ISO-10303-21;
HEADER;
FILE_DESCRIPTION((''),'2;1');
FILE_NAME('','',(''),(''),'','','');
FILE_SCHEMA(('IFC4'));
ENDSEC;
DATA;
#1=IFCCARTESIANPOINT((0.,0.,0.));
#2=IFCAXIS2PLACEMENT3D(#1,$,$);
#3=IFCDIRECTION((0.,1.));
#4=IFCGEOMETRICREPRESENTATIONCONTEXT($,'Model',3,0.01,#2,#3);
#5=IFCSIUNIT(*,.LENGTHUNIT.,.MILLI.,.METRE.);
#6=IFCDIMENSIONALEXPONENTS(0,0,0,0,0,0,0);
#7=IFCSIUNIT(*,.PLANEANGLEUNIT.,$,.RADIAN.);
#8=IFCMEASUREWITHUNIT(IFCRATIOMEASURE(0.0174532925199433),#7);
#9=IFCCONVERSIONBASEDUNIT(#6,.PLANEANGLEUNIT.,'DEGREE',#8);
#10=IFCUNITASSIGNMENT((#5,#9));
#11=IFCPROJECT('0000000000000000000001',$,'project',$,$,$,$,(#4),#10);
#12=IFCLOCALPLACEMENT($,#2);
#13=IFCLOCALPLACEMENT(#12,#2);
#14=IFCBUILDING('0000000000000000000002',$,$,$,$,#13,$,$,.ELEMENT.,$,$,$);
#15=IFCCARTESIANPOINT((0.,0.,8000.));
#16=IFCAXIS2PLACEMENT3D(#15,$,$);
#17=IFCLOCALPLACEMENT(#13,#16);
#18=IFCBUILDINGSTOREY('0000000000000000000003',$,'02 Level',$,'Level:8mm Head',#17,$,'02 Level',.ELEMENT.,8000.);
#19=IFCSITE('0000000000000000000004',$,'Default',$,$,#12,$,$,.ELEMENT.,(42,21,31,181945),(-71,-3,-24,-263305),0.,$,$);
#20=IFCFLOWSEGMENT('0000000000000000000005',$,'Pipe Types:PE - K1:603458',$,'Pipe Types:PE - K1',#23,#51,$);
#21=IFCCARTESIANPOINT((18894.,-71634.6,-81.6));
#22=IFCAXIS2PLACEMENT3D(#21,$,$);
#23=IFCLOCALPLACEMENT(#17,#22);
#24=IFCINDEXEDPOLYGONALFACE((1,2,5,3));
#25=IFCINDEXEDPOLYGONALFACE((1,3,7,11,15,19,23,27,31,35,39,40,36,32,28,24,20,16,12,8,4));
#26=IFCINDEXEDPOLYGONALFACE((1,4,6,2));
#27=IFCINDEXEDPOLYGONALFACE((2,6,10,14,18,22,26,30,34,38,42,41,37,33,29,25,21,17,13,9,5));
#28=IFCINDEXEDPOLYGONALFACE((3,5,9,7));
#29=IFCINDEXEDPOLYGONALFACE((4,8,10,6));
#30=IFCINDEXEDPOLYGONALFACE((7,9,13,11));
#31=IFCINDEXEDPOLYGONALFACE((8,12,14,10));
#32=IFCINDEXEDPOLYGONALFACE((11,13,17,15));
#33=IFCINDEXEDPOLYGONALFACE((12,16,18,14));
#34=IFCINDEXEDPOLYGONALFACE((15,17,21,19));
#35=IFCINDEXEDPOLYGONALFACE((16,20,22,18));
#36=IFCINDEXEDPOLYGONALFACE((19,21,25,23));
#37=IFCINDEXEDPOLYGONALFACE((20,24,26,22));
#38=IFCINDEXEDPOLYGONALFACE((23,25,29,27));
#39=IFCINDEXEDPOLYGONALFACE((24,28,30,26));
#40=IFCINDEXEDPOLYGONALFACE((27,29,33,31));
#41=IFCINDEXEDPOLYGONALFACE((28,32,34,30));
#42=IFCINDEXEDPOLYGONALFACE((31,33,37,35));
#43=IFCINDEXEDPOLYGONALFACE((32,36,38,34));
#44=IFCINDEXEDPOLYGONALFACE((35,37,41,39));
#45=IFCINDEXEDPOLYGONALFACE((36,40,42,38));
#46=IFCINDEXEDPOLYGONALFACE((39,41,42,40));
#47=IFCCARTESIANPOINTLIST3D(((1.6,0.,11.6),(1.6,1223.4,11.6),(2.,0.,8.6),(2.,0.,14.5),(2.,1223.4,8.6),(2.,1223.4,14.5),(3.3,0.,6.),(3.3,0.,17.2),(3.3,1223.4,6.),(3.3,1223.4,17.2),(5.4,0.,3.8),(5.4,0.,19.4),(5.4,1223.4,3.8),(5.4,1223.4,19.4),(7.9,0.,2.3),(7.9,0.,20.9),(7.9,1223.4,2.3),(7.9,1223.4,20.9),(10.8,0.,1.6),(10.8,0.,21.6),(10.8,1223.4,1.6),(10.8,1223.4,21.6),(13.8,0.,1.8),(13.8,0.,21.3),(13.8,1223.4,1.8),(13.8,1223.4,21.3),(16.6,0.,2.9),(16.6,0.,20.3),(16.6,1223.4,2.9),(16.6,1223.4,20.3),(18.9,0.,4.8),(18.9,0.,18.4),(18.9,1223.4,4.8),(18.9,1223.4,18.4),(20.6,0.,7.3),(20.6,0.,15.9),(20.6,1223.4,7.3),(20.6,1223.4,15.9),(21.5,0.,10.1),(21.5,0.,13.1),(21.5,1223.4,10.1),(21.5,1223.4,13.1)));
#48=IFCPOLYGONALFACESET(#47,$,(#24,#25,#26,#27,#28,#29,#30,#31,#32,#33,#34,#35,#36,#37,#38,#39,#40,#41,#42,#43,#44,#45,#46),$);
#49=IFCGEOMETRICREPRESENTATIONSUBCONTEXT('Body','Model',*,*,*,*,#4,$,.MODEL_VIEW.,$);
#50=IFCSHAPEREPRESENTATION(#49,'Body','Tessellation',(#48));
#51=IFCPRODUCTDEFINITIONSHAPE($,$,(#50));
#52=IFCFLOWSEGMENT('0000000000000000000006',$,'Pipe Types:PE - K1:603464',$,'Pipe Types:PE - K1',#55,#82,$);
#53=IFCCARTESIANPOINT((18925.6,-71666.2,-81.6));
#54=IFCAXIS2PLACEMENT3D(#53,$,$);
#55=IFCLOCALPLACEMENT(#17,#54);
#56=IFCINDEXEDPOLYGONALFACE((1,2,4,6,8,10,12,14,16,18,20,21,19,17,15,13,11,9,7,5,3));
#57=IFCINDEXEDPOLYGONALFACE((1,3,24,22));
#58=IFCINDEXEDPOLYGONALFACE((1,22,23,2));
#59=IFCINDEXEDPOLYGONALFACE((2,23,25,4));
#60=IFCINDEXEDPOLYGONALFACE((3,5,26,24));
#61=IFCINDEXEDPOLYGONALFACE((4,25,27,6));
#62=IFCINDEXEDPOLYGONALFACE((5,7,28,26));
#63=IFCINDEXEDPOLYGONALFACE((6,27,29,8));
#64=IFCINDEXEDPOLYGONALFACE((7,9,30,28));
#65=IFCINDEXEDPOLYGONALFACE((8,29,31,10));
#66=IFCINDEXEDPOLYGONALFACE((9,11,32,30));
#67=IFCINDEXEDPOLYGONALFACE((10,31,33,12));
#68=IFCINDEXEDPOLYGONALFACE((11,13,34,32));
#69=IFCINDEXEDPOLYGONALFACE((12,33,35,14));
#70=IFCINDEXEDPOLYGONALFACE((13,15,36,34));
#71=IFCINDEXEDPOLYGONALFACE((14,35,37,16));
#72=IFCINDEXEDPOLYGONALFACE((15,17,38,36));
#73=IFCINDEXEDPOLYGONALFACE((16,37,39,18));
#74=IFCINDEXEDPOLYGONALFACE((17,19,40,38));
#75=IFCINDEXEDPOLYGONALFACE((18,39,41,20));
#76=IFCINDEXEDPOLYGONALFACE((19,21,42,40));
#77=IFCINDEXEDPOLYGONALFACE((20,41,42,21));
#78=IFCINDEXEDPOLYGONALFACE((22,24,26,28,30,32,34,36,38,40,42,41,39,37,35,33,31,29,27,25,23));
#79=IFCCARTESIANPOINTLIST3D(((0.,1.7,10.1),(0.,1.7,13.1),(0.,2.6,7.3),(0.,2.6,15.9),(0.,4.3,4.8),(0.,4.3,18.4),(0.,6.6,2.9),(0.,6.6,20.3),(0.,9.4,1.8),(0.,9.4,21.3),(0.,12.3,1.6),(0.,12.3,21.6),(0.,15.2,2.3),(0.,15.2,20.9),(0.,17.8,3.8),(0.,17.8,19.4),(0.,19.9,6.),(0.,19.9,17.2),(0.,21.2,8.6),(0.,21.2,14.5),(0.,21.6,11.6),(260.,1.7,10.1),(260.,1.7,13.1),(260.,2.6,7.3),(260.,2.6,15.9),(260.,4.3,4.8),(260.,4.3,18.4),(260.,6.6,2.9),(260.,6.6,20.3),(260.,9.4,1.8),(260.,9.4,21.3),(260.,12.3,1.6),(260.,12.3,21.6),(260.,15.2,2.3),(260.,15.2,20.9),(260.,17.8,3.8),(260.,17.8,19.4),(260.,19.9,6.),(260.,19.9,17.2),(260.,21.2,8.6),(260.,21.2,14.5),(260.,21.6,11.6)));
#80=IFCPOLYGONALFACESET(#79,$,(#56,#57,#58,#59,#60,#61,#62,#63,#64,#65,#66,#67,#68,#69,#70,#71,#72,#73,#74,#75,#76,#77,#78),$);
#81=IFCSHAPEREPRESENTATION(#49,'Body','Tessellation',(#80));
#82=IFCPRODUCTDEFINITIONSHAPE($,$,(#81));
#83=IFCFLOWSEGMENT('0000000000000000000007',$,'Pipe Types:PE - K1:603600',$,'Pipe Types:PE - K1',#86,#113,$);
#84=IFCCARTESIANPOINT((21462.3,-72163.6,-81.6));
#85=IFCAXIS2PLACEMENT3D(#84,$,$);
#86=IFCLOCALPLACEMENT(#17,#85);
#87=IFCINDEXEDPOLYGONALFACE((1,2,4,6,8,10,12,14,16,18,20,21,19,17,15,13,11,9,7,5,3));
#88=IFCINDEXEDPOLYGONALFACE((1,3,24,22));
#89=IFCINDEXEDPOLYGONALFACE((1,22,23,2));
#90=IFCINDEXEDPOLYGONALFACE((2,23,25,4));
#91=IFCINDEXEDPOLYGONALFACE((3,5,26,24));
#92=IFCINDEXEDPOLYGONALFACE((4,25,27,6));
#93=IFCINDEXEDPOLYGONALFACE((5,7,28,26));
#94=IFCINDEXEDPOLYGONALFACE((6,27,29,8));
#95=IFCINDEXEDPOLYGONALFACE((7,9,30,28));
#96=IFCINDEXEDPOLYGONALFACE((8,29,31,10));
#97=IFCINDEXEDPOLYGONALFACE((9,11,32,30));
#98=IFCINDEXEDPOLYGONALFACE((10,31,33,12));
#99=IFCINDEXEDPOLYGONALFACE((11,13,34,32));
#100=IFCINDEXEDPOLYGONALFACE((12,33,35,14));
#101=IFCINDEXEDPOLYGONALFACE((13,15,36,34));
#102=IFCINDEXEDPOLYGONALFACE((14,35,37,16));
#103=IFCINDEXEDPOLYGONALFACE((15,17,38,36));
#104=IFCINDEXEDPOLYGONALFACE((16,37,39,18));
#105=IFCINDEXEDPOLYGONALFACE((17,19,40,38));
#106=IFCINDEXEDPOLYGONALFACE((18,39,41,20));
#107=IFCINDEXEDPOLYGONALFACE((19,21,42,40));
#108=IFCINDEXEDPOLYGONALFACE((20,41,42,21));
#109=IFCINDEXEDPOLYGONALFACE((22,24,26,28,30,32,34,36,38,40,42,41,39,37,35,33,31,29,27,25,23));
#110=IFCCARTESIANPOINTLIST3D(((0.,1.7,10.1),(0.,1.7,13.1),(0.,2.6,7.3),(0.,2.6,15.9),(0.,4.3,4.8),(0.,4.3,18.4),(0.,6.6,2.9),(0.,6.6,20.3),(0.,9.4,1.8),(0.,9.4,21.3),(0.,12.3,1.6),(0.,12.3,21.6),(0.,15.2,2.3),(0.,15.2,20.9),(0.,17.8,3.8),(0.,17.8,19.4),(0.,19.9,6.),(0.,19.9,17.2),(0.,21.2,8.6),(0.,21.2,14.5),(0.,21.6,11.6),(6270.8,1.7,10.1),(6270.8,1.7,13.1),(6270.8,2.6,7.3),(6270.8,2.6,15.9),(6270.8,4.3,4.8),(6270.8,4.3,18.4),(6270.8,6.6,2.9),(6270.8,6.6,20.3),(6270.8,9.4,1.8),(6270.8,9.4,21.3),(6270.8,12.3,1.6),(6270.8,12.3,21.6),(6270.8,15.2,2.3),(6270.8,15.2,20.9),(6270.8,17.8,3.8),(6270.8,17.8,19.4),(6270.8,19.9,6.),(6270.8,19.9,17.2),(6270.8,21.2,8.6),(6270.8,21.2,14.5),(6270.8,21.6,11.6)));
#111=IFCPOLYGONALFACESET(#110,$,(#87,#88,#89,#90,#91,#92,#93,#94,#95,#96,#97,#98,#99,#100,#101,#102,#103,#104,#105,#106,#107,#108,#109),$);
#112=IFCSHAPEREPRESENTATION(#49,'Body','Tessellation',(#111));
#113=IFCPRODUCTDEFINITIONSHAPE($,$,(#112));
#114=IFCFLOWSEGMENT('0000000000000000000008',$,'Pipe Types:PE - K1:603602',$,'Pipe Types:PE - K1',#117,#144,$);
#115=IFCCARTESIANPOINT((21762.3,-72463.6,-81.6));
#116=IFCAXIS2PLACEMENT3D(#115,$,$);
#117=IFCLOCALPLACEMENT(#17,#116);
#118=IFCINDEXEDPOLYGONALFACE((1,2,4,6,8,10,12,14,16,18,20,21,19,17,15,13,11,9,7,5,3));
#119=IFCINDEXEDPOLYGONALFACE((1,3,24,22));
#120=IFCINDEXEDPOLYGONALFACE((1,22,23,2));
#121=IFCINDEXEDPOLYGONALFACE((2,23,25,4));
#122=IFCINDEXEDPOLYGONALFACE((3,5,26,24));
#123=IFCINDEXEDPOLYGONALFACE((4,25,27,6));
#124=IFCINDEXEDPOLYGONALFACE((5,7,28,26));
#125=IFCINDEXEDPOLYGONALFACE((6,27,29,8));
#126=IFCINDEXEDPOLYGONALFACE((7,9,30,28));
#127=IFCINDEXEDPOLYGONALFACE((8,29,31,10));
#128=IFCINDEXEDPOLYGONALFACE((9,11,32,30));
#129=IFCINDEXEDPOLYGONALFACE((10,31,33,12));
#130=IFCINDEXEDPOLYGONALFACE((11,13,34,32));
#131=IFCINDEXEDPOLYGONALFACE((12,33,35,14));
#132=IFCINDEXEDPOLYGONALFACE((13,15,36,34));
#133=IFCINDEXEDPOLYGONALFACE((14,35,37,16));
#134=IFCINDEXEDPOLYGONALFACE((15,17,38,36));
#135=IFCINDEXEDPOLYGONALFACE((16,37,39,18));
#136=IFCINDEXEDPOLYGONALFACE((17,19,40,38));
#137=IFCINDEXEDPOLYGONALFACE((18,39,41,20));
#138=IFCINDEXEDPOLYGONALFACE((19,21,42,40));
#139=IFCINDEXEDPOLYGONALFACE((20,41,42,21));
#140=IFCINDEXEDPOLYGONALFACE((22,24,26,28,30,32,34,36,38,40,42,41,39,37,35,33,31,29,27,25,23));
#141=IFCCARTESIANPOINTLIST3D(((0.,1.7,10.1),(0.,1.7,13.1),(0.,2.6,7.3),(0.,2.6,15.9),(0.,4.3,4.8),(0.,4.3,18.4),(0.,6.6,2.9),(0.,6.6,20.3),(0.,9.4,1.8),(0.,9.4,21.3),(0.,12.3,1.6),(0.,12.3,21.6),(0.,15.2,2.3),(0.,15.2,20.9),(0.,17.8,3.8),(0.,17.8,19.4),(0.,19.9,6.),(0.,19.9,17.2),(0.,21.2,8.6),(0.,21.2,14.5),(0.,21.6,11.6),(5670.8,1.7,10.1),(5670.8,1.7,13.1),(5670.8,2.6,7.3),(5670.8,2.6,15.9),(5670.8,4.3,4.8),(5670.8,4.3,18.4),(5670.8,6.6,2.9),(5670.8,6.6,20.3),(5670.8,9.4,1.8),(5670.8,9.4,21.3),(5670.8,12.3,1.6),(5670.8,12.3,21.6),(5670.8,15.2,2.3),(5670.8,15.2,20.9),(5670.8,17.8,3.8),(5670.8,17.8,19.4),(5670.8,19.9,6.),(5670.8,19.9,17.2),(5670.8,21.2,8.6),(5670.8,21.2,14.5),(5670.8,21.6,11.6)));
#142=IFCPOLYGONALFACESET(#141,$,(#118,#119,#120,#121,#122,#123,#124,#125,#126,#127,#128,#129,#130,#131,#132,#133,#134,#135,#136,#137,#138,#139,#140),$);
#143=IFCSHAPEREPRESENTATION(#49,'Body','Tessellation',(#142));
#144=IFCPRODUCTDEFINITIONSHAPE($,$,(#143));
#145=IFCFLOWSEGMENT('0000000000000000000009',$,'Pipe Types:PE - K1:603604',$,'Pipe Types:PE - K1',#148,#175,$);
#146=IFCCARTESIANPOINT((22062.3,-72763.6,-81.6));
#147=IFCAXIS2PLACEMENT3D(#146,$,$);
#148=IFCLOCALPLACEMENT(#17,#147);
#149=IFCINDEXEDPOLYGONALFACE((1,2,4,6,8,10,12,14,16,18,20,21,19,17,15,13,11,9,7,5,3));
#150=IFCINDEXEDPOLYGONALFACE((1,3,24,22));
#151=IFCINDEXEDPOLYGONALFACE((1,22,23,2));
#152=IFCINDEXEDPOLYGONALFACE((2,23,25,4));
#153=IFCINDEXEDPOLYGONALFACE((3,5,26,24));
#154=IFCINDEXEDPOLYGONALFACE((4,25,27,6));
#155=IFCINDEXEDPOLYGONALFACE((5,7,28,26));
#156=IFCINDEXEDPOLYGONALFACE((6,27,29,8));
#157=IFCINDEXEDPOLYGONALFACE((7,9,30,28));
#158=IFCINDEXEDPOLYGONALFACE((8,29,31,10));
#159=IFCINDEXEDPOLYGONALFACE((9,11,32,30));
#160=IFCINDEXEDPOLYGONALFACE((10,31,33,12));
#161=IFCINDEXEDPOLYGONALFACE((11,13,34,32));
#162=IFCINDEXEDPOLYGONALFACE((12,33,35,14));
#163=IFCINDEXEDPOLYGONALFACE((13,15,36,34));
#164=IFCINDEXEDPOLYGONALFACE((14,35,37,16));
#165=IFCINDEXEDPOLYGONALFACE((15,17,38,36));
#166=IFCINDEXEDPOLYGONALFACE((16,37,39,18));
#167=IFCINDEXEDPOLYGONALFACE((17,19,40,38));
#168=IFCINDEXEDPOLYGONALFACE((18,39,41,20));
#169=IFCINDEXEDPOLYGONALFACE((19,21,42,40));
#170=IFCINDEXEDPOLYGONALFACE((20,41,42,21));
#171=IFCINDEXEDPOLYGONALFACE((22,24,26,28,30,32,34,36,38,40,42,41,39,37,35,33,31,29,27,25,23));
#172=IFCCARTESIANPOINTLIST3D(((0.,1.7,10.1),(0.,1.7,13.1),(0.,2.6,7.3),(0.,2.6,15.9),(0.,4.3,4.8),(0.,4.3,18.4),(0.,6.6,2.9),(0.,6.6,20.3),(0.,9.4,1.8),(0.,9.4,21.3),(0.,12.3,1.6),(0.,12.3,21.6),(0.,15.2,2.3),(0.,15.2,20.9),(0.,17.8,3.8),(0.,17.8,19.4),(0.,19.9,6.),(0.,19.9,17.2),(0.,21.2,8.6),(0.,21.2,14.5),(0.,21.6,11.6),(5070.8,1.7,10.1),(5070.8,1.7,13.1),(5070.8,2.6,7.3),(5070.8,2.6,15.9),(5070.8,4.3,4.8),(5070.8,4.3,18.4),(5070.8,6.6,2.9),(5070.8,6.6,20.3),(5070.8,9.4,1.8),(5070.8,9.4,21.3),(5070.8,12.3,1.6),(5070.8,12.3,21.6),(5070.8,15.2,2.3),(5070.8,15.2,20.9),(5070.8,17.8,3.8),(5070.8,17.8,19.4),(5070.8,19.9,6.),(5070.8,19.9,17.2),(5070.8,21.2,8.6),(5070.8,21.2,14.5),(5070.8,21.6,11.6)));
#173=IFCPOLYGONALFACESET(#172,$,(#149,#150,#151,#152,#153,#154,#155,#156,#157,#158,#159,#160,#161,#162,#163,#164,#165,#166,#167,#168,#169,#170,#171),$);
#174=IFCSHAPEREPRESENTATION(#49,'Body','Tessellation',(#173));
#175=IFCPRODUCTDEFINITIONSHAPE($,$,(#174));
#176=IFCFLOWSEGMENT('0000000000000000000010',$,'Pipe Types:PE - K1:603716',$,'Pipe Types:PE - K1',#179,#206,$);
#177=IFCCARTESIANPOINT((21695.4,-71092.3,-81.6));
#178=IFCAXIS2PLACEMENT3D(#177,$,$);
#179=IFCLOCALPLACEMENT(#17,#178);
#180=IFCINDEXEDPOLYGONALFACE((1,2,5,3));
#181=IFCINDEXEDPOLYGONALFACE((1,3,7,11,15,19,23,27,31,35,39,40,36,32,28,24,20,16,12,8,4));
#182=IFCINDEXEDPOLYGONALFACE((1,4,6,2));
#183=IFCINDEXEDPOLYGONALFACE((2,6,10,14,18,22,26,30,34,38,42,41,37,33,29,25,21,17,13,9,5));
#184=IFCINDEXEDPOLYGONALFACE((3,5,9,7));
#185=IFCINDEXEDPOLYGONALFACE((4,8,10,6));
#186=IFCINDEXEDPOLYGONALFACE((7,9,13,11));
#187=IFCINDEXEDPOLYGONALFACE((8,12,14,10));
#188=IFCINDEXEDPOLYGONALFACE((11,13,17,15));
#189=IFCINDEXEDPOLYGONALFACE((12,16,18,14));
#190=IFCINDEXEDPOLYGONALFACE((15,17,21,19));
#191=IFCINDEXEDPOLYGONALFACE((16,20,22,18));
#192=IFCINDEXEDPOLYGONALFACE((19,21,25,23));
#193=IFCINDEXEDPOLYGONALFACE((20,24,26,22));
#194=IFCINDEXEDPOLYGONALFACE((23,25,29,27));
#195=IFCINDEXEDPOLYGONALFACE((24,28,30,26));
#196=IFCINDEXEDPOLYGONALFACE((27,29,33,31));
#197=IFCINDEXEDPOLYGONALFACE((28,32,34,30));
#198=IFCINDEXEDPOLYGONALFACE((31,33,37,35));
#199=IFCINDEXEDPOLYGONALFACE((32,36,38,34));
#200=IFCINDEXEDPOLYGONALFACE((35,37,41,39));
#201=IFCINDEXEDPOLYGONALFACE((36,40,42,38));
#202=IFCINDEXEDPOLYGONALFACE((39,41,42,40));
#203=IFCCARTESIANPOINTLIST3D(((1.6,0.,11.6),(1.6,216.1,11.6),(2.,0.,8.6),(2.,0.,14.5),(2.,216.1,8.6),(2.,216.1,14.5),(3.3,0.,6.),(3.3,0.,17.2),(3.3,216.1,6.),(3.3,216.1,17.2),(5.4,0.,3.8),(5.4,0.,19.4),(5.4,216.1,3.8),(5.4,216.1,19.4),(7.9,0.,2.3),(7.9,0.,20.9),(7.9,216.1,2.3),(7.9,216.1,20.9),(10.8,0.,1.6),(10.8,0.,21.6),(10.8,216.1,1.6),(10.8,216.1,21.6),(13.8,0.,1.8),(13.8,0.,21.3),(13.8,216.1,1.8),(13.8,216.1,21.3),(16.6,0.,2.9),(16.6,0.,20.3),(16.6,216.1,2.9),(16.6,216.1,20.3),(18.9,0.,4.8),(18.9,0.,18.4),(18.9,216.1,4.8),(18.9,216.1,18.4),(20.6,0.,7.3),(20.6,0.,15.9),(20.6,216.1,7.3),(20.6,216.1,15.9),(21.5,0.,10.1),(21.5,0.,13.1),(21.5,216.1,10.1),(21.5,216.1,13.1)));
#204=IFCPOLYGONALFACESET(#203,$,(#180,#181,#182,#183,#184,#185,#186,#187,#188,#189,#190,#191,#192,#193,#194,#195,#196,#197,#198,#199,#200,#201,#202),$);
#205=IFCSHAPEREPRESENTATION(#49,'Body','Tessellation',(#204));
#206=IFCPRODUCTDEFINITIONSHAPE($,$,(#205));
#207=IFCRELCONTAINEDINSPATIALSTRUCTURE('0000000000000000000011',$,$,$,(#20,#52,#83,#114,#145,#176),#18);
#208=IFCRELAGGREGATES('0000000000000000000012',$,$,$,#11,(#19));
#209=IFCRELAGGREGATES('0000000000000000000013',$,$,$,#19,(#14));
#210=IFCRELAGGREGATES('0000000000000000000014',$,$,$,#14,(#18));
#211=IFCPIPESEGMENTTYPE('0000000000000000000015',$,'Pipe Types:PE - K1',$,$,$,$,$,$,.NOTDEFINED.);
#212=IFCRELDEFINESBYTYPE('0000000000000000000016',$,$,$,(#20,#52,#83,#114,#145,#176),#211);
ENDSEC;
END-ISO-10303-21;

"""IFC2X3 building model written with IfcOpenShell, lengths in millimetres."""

from ifc_helpers import new_model, entity, si_unit, converted_unit, direction, frame, frame_2d, origin, origin_2d_with_axis, place, context, subcontext, project, spatial, circle, extrude, type_object, element, save


model = new_model("IFC2X3")

# Units and contexts
model_context = context("Model", 3, precision=0.01, world=origin(), true_north=direction((0.0, 1.0)))
body_context = subcontext(model_context, "Body", "Model", "MODEL_VIEW")
ifc_project = project(units=[si_unit("LENGTHUNIT", "METRE", prefix="MILLI"), converted_unit("PLANEANGLEUNIT", "DEGREE", entity("IfcRatioMeasure", 0.0174532925199433), si_unit("PLANEANGLEUNIT", "RADIAN"), dimensions=[0, 0, 0, 0, 0, 0, 0])], contexts=[model_context])

# Site, building, storey
site_placement = place(None, origin())
site = spatial("IfcSite", under=ifc_project, at=site_placement, Name="Default", CompositionType="ELEMENT", RefLatitude=(42, 21, 31, 181945), RefLongitude=(-71, -3, -24, -263305), RefElevation=0.0)
building_placement = place(site_placement, origin())
building = spatial("IfcBuilding", under=site, at=building_placement, CompositionType="ELEMENT")
storey_placement = place(building_placement, frame((0.0, 0.0, 8000.0)))
storey = spatial("IfcBuildingStorey", under=building, at=storey_placement, Name="02 Level", ObjectType="Level:8mm Head", LongName="02 Level", CompositionType="ELEMENT", Elevation=8000.0)

# Flow segments
pipe_segment_type = type_object("IfcPipeSegmentType", Name="Pipe Types:PE - K1", PredefinedType="NOTDEFINED")
flow_segment_1_placement = place(storey_placement, frame((18894.0, -71634.6, -81.6)))
element("IfcFlowSegment", 1, at=flow_segment_1_placement, inside=storey, type_object=pipe_segment_type, Name="Pipe Types:PE - K1:603458", ObjectType="Pipe Types:PE - K1", context=body_context, shape_type="SweptSolid", body=[
    extrude(circle(Radius=10.0, at=frame_2d((0.0, 0.0), x_axis=(1.0, 0.0))), frame((11.6, 0.0, 11.6), z_axis=(0.0, 1.0, 0.0), x_axis=(-1.0, 0.0, 0.0)), (0.0, 0.0, 1.0), 1223.4),
])
flow_segment_2_placement = place(storey_placement, frame((18925.6, -71666.2, -81.6)))
element("IfcFlowSegment", 2, at=flow_segment_2_placement, inside=storey, type_object=pipe_segment_type, Name="Pipe Types:PE - K1:603464", ObjectType="Pipe Types:PE - K1", context=body_context, shape_type="SweptSolid", body=[
    extrude(circle(Radius=10.0, at=frame_2d((0.0, 0.0), x_axis=(1.0, 0.0))), frame((0.0, 11.6, 11.6), z_axis=(1.0, 0.0, 0.0), x_axis=(0.0, 1.0, 0.0)), (0.0, 0.0, 1.0), 260.0),
])
flow_segment_3_placement = place(storey_placement, frame((21462.3, -72163.6, -81.6)))
element("IfcFlowSegment", 3, at=flow_segment_3_placement, inside=storey, type_object=pipe_segment_type, Name="Pipe Types:PE - K1:603600", ObjectType="Pipe Types:PE - K1", context=body_context, shape_type="SweptSolid", body=[
    extrude(circle(Radius=10.0, at=frame_2d((0.0, 0.0), x_axis=(1.0, 0.0))), frame((0.0, 11.6, 11.6), z_axis=(1.0, 0.0, 0.0), x_axis=(0.0, 1.0, 0.0)), (0.0, 0.0, 1.0), 6270.8),
])
flow_segment_4_placement = place(storey_placement, frame((21762.3, -72463.6, -81.6)))
element("IfcFlowSegment", 4, at=flow_segment_4_placement, inside=storey, type_object=pipe_segment_type, Name="Pipe Types:PE - K1:603602", ObjectType="Pipe Types:PE - K1", context=body_context, shape_type="SweptSolid", body=[
    extrude(circle(Radius=10.0, at=frame_2d((0.0, 0.0), x_axis=(1.0, 0.0))), frame((0.0, 11.6, 11.6), z_axis=(1.0, 0.0, 0.0), x_axis=(0.0, 1.0, 0.0)), (0.0, 0.0, 1.0), 5670.8),
])
flow_segment_5_placement = place(storey_placement, frame((22062.3, -72763.6, -81.6)))
element("IfcFlowSegment", 5, at=flow_segment_5_placement, inside=storey, type_object=pipe_segment_type, Name="Pipe Types:PE - K1:603604", ObjectType="Pipe Types:PE - K1", context=body_context, shape_type="SweptSolid", body=[
    extrude(circle(Radius=10.0, at=frame_2d((0.0, 0.0), x_axis=(1.0, 0.0))), frame((0.0, 11.6, 11.6), z_axis=(1.0, 0.0, 0.0), x_axis=(0.0, 1.0, 0.0)), (0.0, 0.0, 1.0), 5070.8),
])
flow_segment_6_placement = place(storey_placement, frame((21695.4, -71092.3, -81.6)))
element("IfcFlowSegment", 6, at=flow_segment_6_placement, inside=storey, type_object=pipe_segment_type, Name="Pipe Types:PE - K1:603716", ObjectType="Pipe Types:PE - K1", context=body_context, shape_type="SweptSolid", body=[
    extrude(circle(Radius=10.0, at=origin_2d_with_axis()), frame((11.6, 0.0, 11.6), z_axis=(0.0, 1.0, 0.0), x_axis=(-1.0, 0.0, 0.0)), (0.0, 0.0, 1.0), 216.1),
])

save(model, "model.ifc")
